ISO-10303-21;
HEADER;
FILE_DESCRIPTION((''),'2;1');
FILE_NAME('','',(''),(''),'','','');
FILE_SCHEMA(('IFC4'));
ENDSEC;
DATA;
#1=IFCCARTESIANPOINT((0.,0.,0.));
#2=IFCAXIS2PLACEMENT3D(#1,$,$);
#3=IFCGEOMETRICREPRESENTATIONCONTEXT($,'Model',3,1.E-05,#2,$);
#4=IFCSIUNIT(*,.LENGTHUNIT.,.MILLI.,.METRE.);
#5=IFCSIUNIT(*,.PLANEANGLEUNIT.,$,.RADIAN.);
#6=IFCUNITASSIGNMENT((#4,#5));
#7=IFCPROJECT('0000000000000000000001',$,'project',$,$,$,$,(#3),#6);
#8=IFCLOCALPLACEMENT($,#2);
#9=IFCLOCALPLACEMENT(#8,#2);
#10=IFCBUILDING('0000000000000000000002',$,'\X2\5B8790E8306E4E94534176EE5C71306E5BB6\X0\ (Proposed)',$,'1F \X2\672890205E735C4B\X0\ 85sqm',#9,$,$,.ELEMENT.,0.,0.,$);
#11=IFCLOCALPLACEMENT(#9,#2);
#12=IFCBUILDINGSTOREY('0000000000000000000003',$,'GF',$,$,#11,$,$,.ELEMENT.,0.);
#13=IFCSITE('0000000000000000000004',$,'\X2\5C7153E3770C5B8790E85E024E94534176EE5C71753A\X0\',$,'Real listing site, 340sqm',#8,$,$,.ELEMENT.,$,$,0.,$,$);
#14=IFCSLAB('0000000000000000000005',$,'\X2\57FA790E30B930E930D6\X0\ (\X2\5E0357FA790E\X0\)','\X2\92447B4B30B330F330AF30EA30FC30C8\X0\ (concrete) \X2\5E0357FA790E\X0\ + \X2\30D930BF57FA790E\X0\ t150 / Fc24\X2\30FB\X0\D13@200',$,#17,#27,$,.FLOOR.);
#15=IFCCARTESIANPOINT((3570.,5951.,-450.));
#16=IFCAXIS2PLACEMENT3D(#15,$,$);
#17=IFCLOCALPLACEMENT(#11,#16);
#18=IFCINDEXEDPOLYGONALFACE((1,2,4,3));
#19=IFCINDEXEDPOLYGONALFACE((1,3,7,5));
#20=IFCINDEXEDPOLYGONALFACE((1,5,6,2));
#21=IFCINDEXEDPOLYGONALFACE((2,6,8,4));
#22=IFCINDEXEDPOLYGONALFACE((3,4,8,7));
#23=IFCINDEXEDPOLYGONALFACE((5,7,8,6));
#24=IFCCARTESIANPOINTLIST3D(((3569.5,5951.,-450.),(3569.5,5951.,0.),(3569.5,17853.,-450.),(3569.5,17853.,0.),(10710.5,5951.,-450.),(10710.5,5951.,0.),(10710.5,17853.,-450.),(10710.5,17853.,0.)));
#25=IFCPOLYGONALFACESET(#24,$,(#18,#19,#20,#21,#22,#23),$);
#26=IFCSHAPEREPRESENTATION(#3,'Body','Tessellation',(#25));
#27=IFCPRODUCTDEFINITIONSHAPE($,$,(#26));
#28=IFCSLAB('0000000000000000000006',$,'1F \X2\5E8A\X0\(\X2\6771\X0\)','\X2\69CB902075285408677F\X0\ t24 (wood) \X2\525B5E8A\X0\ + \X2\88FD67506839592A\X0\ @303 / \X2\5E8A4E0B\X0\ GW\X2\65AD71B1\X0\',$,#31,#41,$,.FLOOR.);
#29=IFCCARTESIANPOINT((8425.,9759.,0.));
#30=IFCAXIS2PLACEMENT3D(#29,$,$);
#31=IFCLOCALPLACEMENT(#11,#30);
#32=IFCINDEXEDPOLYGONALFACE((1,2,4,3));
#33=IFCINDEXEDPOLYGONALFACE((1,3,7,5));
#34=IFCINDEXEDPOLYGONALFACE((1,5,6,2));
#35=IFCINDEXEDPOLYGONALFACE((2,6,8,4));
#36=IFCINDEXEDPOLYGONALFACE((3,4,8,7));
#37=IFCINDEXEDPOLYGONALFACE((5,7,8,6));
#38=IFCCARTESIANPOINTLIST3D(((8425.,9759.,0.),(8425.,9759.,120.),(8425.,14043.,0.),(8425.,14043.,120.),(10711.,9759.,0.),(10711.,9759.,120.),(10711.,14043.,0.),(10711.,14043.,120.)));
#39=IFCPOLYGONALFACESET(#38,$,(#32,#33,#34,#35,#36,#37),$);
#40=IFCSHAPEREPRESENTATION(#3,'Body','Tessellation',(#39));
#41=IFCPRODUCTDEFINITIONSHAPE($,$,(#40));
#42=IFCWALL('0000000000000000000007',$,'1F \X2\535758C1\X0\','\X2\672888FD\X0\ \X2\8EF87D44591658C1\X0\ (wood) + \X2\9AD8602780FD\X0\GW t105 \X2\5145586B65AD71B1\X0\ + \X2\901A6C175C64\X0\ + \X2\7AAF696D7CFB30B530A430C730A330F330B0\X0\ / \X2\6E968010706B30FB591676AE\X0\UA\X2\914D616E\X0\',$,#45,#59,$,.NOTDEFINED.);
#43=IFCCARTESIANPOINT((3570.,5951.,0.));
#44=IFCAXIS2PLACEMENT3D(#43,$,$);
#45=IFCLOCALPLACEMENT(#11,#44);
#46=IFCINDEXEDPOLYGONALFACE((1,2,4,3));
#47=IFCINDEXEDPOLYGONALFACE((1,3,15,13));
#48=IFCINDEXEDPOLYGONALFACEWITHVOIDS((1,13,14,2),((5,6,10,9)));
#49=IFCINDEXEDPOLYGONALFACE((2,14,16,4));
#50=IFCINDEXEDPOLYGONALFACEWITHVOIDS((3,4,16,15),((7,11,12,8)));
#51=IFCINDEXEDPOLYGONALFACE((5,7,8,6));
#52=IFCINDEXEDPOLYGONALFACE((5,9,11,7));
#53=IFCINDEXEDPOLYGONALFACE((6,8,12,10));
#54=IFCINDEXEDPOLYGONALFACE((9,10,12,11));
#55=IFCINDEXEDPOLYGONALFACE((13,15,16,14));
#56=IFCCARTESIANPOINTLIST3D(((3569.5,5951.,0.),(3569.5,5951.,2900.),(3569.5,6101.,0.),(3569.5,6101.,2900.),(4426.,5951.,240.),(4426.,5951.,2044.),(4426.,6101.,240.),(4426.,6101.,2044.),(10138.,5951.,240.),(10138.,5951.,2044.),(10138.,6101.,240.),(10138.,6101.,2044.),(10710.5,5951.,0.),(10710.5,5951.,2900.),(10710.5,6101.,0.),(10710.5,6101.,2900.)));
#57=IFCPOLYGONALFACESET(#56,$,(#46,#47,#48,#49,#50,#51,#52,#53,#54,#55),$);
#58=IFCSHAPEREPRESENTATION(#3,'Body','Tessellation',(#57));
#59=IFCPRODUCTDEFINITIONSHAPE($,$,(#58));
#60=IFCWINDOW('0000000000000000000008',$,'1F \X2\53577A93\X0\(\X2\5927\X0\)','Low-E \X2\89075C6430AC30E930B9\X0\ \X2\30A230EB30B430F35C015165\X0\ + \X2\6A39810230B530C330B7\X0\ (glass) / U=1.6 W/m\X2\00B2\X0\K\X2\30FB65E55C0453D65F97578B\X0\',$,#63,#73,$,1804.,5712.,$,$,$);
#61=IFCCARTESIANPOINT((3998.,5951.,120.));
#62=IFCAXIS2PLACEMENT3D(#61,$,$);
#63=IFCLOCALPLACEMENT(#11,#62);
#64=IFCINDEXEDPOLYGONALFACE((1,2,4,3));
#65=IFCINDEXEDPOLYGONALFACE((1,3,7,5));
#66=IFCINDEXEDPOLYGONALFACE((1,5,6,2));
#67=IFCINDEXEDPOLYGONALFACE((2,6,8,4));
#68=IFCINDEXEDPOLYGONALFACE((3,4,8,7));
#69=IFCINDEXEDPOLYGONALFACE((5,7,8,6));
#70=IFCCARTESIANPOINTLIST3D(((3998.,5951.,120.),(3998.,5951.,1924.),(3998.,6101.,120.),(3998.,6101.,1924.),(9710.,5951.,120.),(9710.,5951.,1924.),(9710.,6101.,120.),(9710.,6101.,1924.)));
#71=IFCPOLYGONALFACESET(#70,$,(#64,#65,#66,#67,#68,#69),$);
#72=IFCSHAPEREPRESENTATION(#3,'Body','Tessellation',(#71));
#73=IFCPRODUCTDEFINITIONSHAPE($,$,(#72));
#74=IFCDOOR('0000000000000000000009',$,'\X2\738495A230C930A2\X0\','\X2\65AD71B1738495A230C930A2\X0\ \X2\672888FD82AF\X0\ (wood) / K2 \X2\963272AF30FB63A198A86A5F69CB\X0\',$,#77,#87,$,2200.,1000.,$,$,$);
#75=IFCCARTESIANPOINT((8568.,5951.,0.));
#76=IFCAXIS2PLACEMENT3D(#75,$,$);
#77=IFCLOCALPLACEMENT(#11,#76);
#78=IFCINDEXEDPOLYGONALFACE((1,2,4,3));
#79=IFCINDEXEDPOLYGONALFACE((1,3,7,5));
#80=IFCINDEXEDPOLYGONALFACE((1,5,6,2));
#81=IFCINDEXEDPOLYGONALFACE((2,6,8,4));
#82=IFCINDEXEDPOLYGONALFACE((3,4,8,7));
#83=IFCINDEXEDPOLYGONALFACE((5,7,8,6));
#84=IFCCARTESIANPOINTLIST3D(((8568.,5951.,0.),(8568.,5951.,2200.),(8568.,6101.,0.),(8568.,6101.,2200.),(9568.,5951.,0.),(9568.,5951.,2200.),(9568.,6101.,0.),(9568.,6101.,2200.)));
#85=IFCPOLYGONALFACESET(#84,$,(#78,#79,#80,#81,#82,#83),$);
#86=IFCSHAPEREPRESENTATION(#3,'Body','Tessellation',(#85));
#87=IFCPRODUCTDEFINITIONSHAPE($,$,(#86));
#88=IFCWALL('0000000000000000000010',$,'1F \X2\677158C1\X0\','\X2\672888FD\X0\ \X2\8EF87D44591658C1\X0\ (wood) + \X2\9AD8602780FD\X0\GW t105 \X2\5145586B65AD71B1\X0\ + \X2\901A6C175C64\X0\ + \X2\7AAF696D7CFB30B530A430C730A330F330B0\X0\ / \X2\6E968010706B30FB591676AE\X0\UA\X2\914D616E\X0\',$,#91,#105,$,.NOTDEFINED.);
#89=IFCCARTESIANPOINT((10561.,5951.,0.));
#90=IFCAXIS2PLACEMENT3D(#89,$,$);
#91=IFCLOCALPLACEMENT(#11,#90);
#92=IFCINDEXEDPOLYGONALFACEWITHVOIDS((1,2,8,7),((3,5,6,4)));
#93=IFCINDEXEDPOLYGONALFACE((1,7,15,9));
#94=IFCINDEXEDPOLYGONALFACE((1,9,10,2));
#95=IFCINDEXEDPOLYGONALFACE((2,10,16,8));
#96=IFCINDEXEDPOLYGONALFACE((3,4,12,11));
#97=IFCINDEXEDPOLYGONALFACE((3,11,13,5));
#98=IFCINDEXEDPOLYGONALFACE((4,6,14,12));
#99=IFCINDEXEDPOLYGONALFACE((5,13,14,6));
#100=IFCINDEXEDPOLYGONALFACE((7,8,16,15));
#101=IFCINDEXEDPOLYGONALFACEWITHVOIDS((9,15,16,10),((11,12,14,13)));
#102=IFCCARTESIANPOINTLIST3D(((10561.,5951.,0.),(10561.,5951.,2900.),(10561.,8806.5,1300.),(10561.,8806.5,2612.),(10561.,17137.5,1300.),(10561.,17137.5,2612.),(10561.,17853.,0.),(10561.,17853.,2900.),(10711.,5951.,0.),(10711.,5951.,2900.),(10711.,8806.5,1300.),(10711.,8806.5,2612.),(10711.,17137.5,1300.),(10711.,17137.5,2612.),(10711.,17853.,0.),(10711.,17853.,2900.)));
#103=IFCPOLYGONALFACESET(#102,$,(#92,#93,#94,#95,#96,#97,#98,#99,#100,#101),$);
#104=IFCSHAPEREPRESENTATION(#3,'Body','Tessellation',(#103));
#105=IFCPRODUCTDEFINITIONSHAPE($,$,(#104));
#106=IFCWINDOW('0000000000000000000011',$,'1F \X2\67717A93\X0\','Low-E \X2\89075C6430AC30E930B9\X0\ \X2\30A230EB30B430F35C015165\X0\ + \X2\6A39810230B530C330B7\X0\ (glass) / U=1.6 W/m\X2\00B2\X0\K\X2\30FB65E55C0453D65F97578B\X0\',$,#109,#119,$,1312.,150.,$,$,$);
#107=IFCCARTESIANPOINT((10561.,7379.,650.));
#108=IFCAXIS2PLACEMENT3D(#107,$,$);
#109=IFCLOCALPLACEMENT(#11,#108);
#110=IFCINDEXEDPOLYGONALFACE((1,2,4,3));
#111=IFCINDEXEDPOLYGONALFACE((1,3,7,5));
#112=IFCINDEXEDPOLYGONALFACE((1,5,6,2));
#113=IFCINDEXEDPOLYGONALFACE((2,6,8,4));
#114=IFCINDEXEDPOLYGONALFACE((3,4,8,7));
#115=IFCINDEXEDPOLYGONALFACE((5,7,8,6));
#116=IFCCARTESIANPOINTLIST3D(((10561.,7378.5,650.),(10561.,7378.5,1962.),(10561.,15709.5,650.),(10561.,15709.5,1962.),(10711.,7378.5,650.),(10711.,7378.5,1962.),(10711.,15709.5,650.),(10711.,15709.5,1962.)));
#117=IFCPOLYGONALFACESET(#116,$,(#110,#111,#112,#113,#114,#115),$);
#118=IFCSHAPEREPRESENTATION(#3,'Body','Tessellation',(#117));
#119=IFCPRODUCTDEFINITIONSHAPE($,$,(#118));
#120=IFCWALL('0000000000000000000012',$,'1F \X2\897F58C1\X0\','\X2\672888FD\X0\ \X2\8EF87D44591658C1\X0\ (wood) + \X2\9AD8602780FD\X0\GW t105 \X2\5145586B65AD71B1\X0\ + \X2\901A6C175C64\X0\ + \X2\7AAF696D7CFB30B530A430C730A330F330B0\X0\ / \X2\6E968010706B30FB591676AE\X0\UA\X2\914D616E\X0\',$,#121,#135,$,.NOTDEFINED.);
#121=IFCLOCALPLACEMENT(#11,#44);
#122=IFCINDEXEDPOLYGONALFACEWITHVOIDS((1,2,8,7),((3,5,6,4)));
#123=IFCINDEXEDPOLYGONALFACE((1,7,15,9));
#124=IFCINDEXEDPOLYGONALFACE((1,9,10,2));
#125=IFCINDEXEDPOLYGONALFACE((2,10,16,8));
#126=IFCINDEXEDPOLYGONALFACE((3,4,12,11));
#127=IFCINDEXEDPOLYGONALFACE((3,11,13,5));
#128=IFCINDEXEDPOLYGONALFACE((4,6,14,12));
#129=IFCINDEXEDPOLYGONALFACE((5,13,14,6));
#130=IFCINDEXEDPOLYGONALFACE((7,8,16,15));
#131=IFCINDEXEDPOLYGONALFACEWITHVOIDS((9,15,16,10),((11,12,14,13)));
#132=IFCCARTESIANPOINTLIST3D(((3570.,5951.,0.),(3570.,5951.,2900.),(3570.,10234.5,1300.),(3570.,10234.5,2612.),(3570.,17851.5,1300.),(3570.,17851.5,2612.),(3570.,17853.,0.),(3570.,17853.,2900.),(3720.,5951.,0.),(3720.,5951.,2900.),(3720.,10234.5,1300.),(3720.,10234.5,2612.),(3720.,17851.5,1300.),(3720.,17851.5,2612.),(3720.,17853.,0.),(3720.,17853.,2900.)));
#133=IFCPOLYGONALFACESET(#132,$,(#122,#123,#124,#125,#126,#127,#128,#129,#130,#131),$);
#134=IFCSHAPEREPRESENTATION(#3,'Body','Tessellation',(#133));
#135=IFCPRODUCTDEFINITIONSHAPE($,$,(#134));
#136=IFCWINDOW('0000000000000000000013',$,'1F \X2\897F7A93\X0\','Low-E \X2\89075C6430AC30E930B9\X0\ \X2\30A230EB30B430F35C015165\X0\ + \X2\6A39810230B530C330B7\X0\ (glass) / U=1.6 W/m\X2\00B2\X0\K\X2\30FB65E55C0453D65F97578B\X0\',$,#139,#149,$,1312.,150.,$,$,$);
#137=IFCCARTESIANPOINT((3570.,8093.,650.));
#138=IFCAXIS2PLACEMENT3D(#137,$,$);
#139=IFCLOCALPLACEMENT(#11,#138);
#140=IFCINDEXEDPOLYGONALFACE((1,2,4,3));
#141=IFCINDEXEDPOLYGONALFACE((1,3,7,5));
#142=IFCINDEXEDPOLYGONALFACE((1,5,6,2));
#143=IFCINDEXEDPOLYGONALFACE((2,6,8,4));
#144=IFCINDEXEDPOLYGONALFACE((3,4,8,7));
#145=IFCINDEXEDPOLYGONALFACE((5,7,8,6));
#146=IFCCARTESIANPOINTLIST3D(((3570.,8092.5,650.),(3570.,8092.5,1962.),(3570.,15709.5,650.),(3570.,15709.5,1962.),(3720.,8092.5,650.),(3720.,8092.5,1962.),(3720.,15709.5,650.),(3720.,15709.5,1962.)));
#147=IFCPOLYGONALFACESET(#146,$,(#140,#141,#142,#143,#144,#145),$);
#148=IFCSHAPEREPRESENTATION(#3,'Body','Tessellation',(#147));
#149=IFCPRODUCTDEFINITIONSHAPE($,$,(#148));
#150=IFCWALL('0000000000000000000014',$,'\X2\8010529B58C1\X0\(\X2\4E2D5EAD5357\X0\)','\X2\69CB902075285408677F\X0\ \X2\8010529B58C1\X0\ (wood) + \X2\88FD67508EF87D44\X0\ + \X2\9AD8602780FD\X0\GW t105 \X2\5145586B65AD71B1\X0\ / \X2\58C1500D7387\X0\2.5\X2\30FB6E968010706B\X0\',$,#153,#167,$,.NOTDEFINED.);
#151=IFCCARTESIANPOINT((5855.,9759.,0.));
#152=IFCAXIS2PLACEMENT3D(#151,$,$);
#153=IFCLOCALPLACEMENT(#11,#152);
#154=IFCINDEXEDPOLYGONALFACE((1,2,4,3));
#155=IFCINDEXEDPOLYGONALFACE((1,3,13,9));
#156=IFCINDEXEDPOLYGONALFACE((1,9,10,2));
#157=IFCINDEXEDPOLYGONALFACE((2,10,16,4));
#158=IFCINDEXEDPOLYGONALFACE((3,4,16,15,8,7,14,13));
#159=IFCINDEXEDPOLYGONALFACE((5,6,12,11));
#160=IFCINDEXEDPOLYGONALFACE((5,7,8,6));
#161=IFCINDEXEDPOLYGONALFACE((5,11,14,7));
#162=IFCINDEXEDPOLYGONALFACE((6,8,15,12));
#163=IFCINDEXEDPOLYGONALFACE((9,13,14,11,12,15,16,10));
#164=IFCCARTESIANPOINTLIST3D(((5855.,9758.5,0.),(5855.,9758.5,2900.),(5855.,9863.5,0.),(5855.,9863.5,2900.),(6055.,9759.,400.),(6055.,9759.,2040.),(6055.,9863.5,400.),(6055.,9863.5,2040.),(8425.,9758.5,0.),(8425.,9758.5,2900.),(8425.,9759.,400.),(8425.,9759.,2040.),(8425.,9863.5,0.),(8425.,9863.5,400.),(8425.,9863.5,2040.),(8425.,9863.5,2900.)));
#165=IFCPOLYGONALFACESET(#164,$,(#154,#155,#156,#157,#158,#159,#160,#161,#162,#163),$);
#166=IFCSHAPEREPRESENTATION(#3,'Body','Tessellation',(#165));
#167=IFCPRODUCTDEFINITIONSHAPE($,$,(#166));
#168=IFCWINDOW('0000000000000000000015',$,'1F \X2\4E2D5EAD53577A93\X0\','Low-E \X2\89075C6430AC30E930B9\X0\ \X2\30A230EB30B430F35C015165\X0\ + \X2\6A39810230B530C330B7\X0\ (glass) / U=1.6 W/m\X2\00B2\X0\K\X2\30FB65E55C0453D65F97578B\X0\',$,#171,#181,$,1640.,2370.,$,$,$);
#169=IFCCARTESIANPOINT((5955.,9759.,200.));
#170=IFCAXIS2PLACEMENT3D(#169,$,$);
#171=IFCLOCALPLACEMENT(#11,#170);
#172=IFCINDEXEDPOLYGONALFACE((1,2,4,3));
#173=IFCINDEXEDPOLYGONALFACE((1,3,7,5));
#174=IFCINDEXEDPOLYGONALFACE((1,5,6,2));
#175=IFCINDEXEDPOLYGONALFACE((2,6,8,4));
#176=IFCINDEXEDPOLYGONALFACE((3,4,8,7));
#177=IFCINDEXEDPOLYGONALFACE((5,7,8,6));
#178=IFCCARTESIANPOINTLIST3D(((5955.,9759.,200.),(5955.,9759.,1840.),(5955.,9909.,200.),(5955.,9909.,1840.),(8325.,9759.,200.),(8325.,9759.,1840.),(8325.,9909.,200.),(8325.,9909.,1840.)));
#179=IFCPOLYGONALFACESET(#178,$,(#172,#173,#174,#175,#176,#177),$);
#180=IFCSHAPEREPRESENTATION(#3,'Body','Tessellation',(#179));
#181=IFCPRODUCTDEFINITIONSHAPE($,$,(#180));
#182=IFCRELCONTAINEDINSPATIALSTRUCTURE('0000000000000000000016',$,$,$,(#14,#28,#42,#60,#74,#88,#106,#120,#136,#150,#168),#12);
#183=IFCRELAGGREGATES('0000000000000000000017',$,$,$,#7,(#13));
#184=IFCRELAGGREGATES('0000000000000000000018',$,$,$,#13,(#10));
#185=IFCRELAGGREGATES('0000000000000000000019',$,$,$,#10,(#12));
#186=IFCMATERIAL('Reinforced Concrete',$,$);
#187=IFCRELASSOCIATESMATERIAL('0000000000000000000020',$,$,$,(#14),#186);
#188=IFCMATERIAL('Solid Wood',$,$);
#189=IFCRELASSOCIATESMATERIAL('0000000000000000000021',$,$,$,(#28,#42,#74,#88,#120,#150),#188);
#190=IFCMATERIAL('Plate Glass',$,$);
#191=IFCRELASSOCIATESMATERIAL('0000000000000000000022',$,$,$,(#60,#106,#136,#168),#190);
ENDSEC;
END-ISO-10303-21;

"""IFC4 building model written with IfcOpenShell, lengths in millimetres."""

from ifc_helpers import new_model, si_unit, frame, frame_2d, origin, place, context, project, spatial, rectangle, extrude, material, element, fill, save


model = new_model("IFC4")

# Units and contexts
model_context = context("Model", 3, precision=1e-05, world=origin())
ifc_project = project(units=[si_unit("LENGTHUNIT", "METRE", prefix="MILLI"), si_unit("PLANEANGLEUNIT", "RADIAN")], contexts=[model_context])

# Site, building, storey
site_placement = place(None, origin())
site = spatial("IfcSite", under=ifc_project, at=site_placement, Name="山口県宇部市五十目山町", ObjectType="Real listing site, 340sqm", CompositionType="ELEMENT", RefElevation=0.0)
building_placement = place(site_placement, origin())
building = spatial("IfcBuilding", under=site, at=building_placement, Name="宇部の五十目山の家 (Proposed)", ObjectType="1F 木造平屋 85sqm", CompositionType="ELEMENT", ElevationOfRefHeight=0.0, ElevationOfTerrain=0.0)
storey_placement = place(building_placement, origin())
storey = spatial("IfcBuildingStorey", under=building, at=storey_placement, Name="GF", CompositionType="ELEMENT", Elevation=0.0)

# Slabs
ifc_material_1 = material(Name="Reinforced Concrete")
slab_1_placement = place(storey_placement, frame((3570.0, 5951.0, -450.0)))
element("IfcSlab", 1, at=slab_1_placement, inside=storey, material=ifc_material_1, Name="基礎スラブ (布基礎)", Description="鉄筋コンクリート (concrete) 布基礎 + ベタ基礎 t150 / Fc24・D13@200", PredefinedType="FLOOR", context=model_context, shape_type="SweptSolid", body=[
    extrude(rectangle(XDim=7141.0, YDim=11902.0, at=frame_2d((3570.0, 5951.0))), frame((3570.0, 5951.0, -450.0)), (0.0, 0.0, 1.0), 450.0),
])
ifc_material_2 = material(Name="Solid Wood")
slab_2_placement = place(storey_placement, frame((8425.0, 9759.0, 0.0)))
element("IfcSlab", 2, at=slab_2_placement, inside=storey, material=ifc_material_2, Name="1F 床(東)", Description="構造用合板 t24 (wood) 剛床 + 製材根太 @303 / 床下 GW断熱", PredefinedType="FLOOR", context=model_context, shape_type="SweptSolid", body=[
    extrude(rectangle(XDim=2286.0, YDim=4284.0, at=frame_2d((1143.0, 2142.0))), frame((8425.0, 9759.0, 0.0)), (0.0, 0.0, 1.0), 120.0),
])

# Wall, openings, window, door
wall_1_placement = place(storey_placement, frame((3570.0, 5951.0, 0.0)))
wall_1 = element("IfcWall", 3, at=wall_1_placement, inside=storey, material=ifc_material_2, Name="1F 南壁", Description="木製 軸組外壁 (wood) + 高性能GW t105 充填断熱 + 通気層 + 窯業系サイディング / 準耐火・外皮UA配慮", PredefinedType="NOTDEFINED", context=model_context, shape_type="SweptSolid", body=[
    extrude(rectangle(XDim=7141.0, YDim=150.0, at=frame_2d((3570.0, 75.0))), frame((3570.0, 5951.0, 0.0)), (0.0, 0.0, 1.0), 2900.0),
])
opening_1_placement = place(storey_placement, frame((3998.0, 5951.0, 120.0)))
opening_1 = element("IfcOpeningElement", 4, at=opening_1_placement, cuts=wall_1, PredefinedType="NOTDEFINED", context=model_context, shape_type="SweptSolid", body=[
    extrude(rectangle(XDim=5712.0, YDim=150.0, at=frame_2d((2856.0, 75.0))), frame((3998.0, 5951.0, 120.0)), (0.0, 0.0, 1.0), 1804.0),
])
opening_2_placement = place(storey_placement, frame((8568.0, 5951.0, 0.0)))
opening_2 = element("IfcOpeningElement", 5, at=opening_2_placement, cuts=wall_1, PredefinedType="NOTDEFINED", context=model_context, shape_type="SweptSolid", body=[
    extrude(rectangle(XDim=1000.0, YDim=150.0, at=frame_2d((500.0, 75.0))), frame((8568.0, 5951.0, 0.0)), (0.0, 0.0, 1.0), 2200.0),
])
ifc_material_3 = material(Name="Plate Glass")
window_1_placement = place(storey_placement, frame((3998.0, 5951.0, 120.0)))
window_1 = element("IfcWindow", 6, at=window_1_placement, inside=storey, material=ifc_material_3, Name="1F 南窓(大)", Description="Low-E 複層ガラス アルゴン封入 + 樹脂サッシ (glass) / U=1.6 W/m²K・日射取得型", OverallHeight=1804.0, OverallWidth=5712.0, context=model_context, shape_type="SweptSolid", body=[
    extrude(rectangle(XDim=5712.0, YDim=150.0, at=frame_2d((2856.0, 75.0))), frame((3998.0, 5951.0, 120.0)), (0.0, 0.0, 1.0), 1804.0),
])
fill(opening_1, window_1)
door_placement = place(storey_placement, frame((8568.0, 5951.0, 0.0)))
door = element("IfcDoor", 7, at=door_placement, inside=storey, material=ifc_material_2, Name="玄関ドア", Description="断熱玄関ドア 木製芯 (wood) / K2 防犯・採風機構", OverallHeight=2200.0, OverallWidth=1000.0, context=model_context, shape_type="SweptSolid", body=[
    extrude(rectangle(XDim=1000.0, YDim=150.0, at=frame_2d((500.0, 75.0))), frame((8568.0, 5951.0, 0.0)), (0.0, 0.0, 1.0), 2200.0),
])
fill(opening_2, door)

# Walls, openings, windows
wall_2_placement = place(storey_placement, frame((10561.0, 5951.0, 0.0)))
wall_2 = element("IfcWall", 8, at=wall_2_placement, inside=storey, material=ifc_material_2, Name="1F 東壁", Description="木製 軸組外壁 (wood) + 高性能GW t105 充填断熱 + 通気層 + 窯業系サイディング / 準耐火・外皮UA配慮", PredefinedType="NOTDEFINED", context=model_context, shape_type="SweptSolid", body=[
    extrude(rectangle(XDim=150.0, YDim=11902.0, at=frame_2d((75.0, 5951.0))), frame((10561.0, 5951.0, 0.0)), (0.0, 0.0, 1.0), 2900.0),
])
opening_3_placement = place(storey_placement, frame((10561.0, 7379.0, 650.0)))
opening_3 = element("IfcOpeningElement", 9, at=opening_3_placement, cuts=wall_2, PredefinedType="NOTDEFINED", context=model_context, shape_type="SweptSolid", body=[
    extrude(rectangle(XDim=150.0, YDim=8331.0, at=frame_2d((75.0, 4165.0))), frame((10561.0, 7379.0, 650.0)), (0.0, 0.0, 1.0), 1312.0),
])
window_2_placement = place(storey_placement, frame((10561.0, 7379.0, 650.0)))
window_2 = element("IfcWindow", 10, at=window_2_placement, inside=storey, material=ifc_material_3, Name="1F 東窓", Description="Low-E 複層ガラス アルゴン封入 + 樹脂サッシ (glass) / U=1.6 W/m²K・日射取得型", OverallHeight=1312.0, OverallWidth=150.0, context=model_context, shape_type="SweptSolid", body=[
    extrude(rectangle(XDim=150.0, YDim=8331.0, at=frame_2d((75.0, 4165.0))), frame((10561.0, 7379.0, 650.0)), (0.0, 0.0, 1.0), 1312.0),
])
fill(opening_3, window_2)
wall_3_placement = place(storey_placement, frame((3570.0, 5951.0, 0.0)))
wall_3 = element("IfcWall", 11, at=wall_3_placement, inside=storey, material=ifc_material_2, Name="1F 西壁", Description="木製 軸組外壁 (wood) + 高性能GW t105 充填断熱 + 通気層 + 窯業系サイディング / 準耐火・外皮UA配慮", PredefinedType="NOTDEFINED", context=model_context, shape_type="SweptSolid", body=[
    extrude(rectangle(XDim=150.0, YDim=11902.0, at=frame_2d((75.0, 5951.0))), frame((3570.0, 5951.0, 0.0)), (0.0, 0.0, 1.0), 2900.0),
])
opening_4_placement = place(storey_placement, frame((3570.0, 8093.0, 650.0)))
opening_4 = element("IfcOpeningElement", 12, at=opening_4_placement, cuts=wall_3, PredefinedType="NOTDEFINED", context=model_context, shape_type="SweptSolid", body=[
    extrude(rectangle(XDim=150.0, YDim=7617.0, at=frame_2d((75.0, 3808.0))), frame((3570.0, 8093.0, 650.0)), (0.0, 0.0, 1.0), 1312.0),
])
window_3_placement = place(storey_placement, frame((3570.0, 8093.0, 650.0)))
window_3 = element("IfcWindow", 13, at=window_3_placement, inside=storey, material=ifc_material_3, Name="1F 西窓", Description="Low-E 複層ガラス アルゴン封入 + 樹脂サッシ (glass) / U=1.6 W/m²K・日射取得型", OverallHeight=1312.0, OverallWidth=150.0, context=model_context, shape_type="SweptSolid", body=[
    extrude(rectangle(XDim=150.0, YDim=7617.0, at=frame_2d((75.0, 3808.0))), frame((3570.0, 8093.0, 650.0)), (0.0, 0.0, 1.0), 1312.0),
])
fill(opening_4, window_3)
wall_4_placement = place(storey_placement, frame((5855.0, 9759.0, 0.0)))
wall_4 = element("IfcWall", 14, at=wall_4_placement, inside=storey, material=ifc_material_2, Name="耐力壁(中庭南)", Description="構造用合板 耐力壁 (wood) + 製材軸組 + 高性能GW t105 充填断熱 / 壁倍率2.5・準耐火", PredefinedType="NOTDEFINED", context=model_context, shape_type="SweptSolid", body=[
    extrude(rectangle(XDim=2570.0, YDim=105.0, at=frame_2d((1285.0, 52.0))), frame((5855.0, 9759.0, 0.0)), (0.0, 0.0, 1.0), 2900.0),
])
opening_5_placement = place(storey_placement, frame((5955.0, 9759.0, 200.0)))
opening_5 = element("IfcOpeningElement", 15, at=opening_5_placement, cuts=wall_4, PredefinedType="NOTDEFINED", context=model_context, shape_type="SweptSolid", body=[
    extrude(rectangle(XDim=2370.0, YDim=150.0, at=frame_2d((1185.0, 75.0))), frame((5955.0, 9759.0, 200.0)), (0.0, 0.0, 1.0), 1640.0),
])
window_4_placement = place(storey_placement, frame((5955.0, 9759.0, 200.0)))
window_4 = element("IfcWindow", 16, at=window_4_placement, inside=storey, material=ifc_material_3, Name="1F 中庭南窓", Description="Low-E 複層ガラス アルゴン封入 + 樹脂サッシ (glass) / U=1.6 W/m²K・日射取得型", OverallHeight=1640.0, OverallWidth=2370.0, context=model_context, shape_type="SweptSolid", body=[
    extrude(rectangle(XDim=2370.0, YDim=150.0, at=frame_2d((1185.0, 75.0))), frame((5955.0, 9759.0, 200.0)), (0.0, 0.0, 1.0), 1640.0),
])
fill(opening_5, window_4)

save(model, "model.ifc")
